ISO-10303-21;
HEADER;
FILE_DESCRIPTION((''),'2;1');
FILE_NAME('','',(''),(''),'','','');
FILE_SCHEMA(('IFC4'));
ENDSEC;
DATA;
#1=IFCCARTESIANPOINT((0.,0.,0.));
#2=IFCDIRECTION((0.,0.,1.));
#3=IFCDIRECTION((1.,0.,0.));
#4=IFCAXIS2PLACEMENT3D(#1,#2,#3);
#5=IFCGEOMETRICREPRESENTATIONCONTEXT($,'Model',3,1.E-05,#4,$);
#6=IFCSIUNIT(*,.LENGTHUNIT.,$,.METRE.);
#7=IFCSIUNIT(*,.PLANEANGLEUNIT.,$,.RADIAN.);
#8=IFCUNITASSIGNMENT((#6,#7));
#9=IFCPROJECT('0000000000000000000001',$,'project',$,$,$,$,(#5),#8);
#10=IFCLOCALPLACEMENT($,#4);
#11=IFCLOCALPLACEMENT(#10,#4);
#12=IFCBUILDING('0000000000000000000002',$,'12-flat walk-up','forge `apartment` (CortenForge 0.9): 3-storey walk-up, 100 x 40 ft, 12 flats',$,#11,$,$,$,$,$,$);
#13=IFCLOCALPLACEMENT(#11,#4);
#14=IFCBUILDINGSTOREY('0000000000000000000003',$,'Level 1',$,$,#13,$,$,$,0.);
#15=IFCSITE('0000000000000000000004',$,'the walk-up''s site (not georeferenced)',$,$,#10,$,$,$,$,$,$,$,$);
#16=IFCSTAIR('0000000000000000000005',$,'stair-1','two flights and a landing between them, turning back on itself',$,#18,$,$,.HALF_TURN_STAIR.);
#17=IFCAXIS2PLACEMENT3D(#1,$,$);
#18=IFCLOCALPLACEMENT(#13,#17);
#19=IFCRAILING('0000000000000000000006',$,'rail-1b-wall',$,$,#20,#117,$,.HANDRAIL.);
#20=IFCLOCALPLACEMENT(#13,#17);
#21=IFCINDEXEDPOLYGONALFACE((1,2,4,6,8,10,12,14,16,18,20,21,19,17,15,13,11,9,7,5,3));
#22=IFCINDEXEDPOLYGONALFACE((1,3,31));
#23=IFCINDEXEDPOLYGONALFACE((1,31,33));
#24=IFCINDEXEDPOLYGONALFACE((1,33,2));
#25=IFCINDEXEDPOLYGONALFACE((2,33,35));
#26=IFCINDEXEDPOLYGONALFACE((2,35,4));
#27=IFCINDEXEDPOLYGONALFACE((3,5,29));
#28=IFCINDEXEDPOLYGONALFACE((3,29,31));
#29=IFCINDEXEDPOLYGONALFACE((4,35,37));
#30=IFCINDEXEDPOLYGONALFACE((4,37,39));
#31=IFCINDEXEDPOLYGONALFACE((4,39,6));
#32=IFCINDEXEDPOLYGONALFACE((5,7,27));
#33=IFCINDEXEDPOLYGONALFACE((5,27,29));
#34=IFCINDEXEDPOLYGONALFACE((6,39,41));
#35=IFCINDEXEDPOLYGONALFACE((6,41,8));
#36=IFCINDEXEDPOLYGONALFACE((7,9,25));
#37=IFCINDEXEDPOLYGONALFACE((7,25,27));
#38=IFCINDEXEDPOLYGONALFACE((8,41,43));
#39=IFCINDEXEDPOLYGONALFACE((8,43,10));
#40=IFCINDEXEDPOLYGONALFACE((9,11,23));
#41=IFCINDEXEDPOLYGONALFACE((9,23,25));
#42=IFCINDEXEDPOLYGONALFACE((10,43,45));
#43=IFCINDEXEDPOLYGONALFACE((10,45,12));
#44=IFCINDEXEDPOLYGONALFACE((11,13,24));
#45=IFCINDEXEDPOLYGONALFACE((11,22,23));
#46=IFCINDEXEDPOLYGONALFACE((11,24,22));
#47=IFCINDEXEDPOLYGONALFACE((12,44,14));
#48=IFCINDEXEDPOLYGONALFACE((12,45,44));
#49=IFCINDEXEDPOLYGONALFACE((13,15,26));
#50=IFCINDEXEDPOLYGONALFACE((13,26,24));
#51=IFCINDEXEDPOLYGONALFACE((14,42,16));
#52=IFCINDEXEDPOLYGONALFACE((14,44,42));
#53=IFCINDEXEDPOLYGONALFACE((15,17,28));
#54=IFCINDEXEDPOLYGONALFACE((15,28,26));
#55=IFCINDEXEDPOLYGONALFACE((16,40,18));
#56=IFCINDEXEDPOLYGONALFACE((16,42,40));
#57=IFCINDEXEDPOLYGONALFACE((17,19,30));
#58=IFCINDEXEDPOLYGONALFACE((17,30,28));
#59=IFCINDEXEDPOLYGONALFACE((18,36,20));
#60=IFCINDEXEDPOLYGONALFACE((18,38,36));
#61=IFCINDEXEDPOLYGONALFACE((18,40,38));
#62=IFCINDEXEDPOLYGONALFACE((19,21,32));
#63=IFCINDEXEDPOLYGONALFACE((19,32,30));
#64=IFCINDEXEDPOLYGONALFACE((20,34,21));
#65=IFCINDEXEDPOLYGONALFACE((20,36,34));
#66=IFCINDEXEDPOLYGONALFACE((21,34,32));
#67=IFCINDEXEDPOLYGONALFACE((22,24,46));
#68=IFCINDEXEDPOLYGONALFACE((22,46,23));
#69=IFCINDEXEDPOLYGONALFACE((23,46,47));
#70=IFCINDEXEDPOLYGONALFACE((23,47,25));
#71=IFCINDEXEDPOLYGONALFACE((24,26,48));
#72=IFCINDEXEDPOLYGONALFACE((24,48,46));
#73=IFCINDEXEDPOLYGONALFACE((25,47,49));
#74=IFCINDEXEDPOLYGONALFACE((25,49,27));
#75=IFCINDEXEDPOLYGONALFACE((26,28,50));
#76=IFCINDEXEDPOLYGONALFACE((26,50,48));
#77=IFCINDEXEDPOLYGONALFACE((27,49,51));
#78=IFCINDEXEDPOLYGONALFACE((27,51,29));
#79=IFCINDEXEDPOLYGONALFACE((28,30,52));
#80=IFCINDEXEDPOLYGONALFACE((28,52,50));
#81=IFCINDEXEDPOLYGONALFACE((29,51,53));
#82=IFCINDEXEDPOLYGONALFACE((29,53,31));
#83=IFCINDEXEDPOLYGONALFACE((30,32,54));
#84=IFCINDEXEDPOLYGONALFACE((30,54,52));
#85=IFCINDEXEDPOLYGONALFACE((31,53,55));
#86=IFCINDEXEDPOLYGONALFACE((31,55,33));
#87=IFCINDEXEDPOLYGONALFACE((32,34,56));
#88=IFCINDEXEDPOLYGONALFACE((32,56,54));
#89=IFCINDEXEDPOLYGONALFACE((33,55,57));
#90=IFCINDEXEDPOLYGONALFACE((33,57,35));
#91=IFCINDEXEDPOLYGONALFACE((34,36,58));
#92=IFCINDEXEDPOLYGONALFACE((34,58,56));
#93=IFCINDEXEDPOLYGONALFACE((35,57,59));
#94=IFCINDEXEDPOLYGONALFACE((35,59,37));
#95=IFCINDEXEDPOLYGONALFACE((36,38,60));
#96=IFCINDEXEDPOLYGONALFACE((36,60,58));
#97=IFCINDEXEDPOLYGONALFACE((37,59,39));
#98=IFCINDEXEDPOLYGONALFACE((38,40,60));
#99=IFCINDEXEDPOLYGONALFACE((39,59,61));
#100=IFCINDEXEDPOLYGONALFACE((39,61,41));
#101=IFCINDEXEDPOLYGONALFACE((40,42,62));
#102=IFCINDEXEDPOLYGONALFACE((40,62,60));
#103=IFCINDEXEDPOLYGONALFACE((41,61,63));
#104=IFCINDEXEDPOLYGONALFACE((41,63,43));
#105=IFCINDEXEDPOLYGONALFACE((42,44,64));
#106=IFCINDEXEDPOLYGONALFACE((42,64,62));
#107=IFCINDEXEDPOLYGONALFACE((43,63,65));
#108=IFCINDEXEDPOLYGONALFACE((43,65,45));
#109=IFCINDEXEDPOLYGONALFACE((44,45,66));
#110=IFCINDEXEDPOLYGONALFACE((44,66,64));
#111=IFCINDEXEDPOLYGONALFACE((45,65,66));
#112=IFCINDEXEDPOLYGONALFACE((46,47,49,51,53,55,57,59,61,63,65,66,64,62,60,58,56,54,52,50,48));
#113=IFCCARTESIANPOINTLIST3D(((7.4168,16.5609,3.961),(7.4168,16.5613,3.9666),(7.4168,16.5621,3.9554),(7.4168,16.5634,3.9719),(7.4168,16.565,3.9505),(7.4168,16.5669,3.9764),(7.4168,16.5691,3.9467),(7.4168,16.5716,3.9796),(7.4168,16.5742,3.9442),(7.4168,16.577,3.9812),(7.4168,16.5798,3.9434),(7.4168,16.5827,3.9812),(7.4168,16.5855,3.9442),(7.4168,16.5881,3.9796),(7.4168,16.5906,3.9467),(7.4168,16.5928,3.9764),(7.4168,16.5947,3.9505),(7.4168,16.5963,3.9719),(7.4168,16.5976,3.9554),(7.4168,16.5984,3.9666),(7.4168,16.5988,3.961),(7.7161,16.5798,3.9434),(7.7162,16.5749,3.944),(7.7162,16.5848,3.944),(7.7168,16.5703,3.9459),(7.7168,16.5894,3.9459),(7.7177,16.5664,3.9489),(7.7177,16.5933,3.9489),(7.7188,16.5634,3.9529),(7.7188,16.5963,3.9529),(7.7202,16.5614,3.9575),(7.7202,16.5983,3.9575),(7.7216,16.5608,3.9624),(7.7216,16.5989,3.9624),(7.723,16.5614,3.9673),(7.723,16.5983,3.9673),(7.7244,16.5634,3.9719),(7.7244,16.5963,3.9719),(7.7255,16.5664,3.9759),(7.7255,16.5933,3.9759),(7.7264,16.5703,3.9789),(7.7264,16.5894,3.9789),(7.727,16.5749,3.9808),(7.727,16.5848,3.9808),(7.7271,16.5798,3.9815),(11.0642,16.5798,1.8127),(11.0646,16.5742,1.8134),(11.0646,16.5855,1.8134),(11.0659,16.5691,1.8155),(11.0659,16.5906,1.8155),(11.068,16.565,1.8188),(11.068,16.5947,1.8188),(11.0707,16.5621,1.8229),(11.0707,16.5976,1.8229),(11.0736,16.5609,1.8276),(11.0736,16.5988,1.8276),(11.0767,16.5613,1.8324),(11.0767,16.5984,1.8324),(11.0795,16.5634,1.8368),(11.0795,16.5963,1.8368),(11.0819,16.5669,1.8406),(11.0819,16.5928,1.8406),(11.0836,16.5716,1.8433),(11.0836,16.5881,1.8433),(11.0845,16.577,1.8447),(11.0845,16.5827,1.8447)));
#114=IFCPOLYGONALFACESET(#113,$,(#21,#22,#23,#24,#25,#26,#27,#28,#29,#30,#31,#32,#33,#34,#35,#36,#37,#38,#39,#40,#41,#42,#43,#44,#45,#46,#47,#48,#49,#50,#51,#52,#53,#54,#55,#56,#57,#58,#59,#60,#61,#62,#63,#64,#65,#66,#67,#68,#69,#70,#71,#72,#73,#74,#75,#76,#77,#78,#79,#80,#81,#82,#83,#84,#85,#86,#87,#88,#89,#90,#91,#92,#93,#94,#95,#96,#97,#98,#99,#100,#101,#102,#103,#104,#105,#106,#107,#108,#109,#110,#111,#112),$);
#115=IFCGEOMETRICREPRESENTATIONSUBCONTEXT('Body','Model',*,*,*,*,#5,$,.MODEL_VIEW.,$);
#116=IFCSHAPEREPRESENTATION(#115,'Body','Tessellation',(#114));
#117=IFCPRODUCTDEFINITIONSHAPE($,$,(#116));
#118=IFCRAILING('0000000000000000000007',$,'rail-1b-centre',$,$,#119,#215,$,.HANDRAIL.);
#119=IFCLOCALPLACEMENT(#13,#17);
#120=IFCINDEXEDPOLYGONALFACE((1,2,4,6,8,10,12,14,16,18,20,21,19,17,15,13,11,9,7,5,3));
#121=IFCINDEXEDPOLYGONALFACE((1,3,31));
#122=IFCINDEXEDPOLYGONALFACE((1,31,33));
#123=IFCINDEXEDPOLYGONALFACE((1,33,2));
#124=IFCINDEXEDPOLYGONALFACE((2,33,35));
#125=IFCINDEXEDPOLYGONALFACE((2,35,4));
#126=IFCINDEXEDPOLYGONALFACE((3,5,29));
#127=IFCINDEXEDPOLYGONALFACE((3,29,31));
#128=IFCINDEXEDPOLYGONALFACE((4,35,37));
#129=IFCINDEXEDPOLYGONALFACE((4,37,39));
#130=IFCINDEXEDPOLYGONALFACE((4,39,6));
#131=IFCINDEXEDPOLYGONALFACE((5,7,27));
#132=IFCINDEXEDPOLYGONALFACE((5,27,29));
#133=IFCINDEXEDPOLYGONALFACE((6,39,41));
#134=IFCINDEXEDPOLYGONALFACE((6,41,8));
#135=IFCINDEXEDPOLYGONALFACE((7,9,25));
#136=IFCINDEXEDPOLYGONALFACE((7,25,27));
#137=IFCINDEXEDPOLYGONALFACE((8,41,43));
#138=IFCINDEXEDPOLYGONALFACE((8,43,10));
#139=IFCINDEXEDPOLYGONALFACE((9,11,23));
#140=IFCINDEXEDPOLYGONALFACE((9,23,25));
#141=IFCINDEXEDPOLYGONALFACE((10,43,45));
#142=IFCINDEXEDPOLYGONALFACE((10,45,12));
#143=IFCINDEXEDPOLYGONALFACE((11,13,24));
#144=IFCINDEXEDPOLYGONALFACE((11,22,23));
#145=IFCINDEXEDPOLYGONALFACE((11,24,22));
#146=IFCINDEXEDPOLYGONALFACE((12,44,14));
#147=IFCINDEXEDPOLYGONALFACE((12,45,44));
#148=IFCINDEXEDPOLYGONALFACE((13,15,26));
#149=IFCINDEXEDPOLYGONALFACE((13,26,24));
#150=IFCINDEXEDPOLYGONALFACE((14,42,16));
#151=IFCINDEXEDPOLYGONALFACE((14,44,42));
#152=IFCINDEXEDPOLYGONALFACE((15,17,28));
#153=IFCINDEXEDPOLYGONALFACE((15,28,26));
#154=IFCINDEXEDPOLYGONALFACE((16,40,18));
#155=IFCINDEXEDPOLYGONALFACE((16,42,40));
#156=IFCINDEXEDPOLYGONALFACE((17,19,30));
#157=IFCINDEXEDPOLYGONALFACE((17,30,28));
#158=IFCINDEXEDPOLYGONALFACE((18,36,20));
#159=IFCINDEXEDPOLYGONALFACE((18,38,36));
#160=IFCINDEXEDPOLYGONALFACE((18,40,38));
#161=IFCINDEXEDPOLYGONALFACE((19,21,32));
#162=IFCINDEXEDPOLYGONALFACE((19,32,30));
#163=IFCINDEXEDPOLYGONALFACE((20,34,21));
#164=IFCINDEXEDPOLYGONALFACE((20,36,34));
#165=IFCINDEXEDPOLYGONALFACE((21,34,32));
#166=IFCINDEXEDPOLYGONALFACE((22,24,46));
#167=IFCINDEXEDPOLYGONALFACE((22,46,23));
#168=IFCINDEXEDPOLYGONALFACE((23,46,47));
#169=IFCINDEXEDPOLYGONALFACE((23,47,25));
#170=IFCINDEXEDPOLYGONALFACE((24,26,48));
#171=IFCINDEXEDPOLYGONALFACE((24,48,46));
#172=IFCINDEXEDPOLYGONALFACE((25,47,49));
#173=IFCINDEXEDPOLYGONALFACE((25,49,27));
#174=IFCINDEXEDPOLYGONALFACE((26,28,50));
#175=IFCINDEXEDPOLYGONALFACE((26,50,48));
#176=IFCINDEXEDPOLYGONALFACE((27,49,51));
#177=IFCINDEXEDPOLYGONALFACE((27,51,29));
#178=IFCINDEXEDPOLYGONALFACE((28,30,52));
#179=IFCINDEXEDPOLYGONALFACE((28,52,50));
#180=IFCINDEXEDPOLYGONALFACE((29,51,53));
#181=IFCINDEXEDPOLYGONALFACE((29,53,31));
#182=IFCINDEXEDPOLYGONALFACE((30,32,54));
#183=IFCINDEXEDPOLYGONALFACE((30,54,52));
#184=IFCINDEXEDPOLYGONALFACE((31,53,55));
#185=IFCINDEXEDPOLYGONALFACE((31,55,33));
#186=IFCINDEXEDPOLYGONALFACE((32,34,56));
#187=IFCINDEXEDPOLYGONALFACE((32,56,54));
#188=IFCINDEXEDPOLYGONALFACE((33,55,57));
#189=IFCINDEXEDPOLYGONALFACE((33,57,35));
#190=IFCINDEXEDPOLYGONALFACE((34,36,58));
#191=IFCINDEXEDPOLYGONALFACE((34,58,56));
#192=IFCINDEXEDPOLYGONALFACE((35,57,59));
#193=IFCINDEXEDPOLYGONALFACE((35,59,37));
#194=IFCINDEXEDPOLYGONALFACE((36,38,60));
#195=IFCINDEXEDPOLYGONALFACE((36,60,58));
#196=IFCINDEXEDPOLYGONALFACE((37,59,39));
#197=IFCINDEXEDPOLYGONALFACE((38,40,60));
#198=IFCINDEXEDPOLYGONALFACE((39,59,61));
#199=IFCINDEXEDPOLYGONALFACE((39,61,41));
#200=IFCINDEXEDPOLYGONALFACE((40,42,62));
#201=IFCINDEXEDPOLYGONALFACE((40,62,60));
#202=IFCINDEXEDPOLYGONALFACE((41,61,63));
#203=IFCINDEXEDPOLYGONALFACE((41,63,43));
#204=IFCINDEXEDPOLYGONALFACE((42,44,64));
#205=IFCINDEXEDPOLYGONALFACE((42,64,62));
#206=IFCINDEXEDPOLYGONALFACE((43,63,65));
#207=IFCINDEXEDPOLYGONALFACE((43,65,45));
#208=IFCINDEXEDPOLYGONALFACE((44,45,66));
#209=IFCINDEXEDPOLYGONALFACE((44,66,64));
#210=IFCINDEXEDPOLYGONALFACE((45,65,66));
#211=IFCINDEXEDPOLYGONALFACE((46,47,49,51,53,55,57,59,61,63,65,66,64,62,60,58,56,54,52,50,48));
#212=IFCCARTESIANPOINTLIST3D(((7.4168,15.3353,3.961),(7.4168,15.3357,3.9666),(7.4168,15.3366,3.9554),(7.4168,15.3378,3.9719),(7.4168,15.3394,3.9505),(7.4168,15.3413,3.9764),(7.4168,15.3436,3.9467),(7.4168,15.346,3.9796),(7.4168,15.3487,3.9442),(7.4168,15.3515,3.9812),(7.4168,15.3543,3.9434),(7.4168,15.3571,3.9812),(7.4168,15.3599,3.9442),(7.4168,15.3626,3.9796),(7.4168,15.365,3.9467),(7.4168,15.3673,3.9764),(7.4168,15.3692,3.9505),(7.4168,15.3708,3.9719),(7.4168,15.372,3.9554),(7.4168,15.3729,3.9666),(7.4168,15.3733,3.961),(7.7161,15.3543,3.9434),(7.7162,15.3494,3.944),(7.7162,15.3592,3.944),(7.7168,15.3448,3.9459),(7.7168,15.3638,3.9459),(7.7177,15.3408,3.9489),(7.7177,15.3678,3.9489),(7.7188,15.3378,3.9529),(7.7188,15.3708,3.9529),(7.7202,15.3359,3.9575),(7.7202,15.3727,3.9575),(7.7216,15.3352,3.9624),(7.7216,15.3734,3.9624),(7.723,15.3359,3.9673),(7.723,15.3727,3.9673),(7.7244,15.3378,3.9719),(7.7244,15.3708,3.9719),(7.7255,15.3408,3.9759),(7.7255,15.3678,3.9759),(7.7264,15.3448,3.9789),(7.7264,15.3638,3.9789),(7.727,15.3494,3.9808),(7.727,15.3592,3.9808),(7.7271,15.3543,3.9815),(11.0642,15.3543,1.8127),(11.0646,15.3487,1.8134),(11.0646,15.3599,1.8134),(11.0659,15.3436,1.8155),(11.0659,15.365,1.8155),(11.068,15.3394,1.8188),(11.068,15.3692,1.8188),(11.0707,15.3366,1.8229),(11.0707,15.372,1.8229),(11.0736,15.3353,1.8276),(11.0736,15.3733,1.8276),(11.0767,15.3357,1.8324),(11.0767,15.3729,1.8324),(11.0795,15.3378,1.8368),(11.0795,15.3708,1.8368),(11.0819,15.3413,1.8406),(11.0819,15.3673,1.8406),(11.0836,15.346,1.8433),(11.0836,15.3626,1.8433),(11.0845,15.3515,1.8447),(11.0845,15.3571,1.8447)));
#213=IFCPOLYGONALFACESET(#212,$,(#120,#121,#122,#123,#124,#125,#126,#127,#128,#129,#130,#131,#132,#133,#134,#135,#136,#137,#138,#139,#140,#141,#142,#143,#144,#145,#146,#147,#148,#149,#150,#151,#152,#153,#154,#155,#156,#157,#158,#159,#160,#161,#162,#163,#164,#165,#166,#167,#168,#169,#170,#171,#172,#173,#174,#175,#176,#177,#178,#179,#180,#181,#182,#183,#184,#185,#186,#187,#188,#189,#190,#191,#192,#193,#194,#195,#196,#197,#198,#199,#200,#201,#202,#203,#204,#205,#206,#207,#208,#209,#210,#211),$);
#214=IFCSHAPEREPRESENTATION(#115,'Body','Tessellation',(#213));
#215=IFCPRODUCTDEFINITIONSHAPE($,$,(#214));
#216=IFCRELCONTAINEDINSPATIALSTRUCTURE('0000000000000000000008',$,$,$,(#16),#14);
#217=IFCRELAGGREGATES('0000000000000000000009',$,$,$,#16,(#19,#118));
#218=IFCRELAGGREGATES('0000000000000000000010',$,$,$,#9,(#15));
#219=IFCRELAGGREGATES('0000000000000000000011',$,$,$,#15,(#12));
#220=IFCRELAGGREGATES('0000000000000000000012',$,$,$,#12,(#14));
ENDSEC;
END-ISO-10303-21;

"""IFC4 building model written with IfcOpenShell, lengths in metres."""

from ifc_helpers import new_model, entity, si_unit, frame, origin_with_axes, place, context, subcontext, project, spatial, element, aggregate, save


model = new_model("IFC4")

# Units and contexts
model_context = context("Model", 3, precision=1e-05, world=origin_with_axes())
body_context = subcontext(model_context, "Body", "Model", "MODEL_VIEW")
ifc_project = project(units=[si_unit("LENGTHUNIT", "METRE"), si_unit("PLANEANGLEUNIT", "RADIAN")], contexts=[model_context])

# Site, building, storey
site_placement = place(None, origin_with_axes())
site = spatial("IfcSite", under=ifc_project, at=site_placement, Name="the walk-up's site (not georeferenced)")
building_placement = place(site_placement, origin_with_axes())
building = spatial("IfcBuilding", under=site, at=building_placement, Name="12-flat walk-up", Description="forge `apartment` (CortenForge 0.9): 3-storey walk-up, 100 x 40 ft, 12 flats")
storey_placement = place(building_placement, origin_with_axes())
storey = spatial("IfcBuildingStorey", under=building, at=storey_placement, Name="Level 1", Elevation=0.0)

# Stair, railings
stair_placement = place(storey_placement, origin_with_axes())
stair = element("IfcStair", 1, at=stair_placement, inside=storey, Name="stair-1", Description="two flights and a landing between them, turning back on itself", PredefinedType="HALF_TURN_STAIR")
railing_1_placement = place(stair_placement, frame((11.0744, 16.5799, 1.8288), z_axis=(0.0, 0.0, 1.0), x_axis=(1.0, 0.0, 0.0)))
railing_1 = element("IfcRailing", 2, at=railing_1_placement, Name="rail-1b-wall", PredefinedType="HANDRAIL", context=body_context, shape_type="AdvancedSweptSolid", body=[
    entity("IfcSweptDiskSolid", entity("IfcPolyline", [entity("IfcCartesianPoint", [0.0, 0.0, 0.0]), entity("IfcCartesianPoint", [-3.3528, 0.0, 2.1336]), entity("IfcCartesianPoint", [-3.6576, 0.0, 2.1336])]), 0.0191),
])
railing_2_placement = place(stair_placement, frame((11.0744, 15.3543, 1.8288), z_axis=(0.0, 0.0, 1.0), x_axis=(1.0, 0.0, 0.0)))
railing_2 = element("IfcRailing", 3, at=railing_2_placement, Name="rail-1b-centre", PredefinedType="HANDRAIL", context=body_context, shape_type="AdvancedSweptSolid", body=[
    entity("IfcSweptDiskSolid", entity("IfcPolyline", [entity("IfcCartesianPoint", [0.0, 0.0, 0.0]), entity("IfcCartesianPoint", [-3.3528, 0.0, 2.1336]), entity("IfcCartesianPoint", [-3.6576, 0.0, 2.1336])]), 0.0191),
])
aggregate(stair, [railing_1, railing_2])

save(model, "model.ifc")
